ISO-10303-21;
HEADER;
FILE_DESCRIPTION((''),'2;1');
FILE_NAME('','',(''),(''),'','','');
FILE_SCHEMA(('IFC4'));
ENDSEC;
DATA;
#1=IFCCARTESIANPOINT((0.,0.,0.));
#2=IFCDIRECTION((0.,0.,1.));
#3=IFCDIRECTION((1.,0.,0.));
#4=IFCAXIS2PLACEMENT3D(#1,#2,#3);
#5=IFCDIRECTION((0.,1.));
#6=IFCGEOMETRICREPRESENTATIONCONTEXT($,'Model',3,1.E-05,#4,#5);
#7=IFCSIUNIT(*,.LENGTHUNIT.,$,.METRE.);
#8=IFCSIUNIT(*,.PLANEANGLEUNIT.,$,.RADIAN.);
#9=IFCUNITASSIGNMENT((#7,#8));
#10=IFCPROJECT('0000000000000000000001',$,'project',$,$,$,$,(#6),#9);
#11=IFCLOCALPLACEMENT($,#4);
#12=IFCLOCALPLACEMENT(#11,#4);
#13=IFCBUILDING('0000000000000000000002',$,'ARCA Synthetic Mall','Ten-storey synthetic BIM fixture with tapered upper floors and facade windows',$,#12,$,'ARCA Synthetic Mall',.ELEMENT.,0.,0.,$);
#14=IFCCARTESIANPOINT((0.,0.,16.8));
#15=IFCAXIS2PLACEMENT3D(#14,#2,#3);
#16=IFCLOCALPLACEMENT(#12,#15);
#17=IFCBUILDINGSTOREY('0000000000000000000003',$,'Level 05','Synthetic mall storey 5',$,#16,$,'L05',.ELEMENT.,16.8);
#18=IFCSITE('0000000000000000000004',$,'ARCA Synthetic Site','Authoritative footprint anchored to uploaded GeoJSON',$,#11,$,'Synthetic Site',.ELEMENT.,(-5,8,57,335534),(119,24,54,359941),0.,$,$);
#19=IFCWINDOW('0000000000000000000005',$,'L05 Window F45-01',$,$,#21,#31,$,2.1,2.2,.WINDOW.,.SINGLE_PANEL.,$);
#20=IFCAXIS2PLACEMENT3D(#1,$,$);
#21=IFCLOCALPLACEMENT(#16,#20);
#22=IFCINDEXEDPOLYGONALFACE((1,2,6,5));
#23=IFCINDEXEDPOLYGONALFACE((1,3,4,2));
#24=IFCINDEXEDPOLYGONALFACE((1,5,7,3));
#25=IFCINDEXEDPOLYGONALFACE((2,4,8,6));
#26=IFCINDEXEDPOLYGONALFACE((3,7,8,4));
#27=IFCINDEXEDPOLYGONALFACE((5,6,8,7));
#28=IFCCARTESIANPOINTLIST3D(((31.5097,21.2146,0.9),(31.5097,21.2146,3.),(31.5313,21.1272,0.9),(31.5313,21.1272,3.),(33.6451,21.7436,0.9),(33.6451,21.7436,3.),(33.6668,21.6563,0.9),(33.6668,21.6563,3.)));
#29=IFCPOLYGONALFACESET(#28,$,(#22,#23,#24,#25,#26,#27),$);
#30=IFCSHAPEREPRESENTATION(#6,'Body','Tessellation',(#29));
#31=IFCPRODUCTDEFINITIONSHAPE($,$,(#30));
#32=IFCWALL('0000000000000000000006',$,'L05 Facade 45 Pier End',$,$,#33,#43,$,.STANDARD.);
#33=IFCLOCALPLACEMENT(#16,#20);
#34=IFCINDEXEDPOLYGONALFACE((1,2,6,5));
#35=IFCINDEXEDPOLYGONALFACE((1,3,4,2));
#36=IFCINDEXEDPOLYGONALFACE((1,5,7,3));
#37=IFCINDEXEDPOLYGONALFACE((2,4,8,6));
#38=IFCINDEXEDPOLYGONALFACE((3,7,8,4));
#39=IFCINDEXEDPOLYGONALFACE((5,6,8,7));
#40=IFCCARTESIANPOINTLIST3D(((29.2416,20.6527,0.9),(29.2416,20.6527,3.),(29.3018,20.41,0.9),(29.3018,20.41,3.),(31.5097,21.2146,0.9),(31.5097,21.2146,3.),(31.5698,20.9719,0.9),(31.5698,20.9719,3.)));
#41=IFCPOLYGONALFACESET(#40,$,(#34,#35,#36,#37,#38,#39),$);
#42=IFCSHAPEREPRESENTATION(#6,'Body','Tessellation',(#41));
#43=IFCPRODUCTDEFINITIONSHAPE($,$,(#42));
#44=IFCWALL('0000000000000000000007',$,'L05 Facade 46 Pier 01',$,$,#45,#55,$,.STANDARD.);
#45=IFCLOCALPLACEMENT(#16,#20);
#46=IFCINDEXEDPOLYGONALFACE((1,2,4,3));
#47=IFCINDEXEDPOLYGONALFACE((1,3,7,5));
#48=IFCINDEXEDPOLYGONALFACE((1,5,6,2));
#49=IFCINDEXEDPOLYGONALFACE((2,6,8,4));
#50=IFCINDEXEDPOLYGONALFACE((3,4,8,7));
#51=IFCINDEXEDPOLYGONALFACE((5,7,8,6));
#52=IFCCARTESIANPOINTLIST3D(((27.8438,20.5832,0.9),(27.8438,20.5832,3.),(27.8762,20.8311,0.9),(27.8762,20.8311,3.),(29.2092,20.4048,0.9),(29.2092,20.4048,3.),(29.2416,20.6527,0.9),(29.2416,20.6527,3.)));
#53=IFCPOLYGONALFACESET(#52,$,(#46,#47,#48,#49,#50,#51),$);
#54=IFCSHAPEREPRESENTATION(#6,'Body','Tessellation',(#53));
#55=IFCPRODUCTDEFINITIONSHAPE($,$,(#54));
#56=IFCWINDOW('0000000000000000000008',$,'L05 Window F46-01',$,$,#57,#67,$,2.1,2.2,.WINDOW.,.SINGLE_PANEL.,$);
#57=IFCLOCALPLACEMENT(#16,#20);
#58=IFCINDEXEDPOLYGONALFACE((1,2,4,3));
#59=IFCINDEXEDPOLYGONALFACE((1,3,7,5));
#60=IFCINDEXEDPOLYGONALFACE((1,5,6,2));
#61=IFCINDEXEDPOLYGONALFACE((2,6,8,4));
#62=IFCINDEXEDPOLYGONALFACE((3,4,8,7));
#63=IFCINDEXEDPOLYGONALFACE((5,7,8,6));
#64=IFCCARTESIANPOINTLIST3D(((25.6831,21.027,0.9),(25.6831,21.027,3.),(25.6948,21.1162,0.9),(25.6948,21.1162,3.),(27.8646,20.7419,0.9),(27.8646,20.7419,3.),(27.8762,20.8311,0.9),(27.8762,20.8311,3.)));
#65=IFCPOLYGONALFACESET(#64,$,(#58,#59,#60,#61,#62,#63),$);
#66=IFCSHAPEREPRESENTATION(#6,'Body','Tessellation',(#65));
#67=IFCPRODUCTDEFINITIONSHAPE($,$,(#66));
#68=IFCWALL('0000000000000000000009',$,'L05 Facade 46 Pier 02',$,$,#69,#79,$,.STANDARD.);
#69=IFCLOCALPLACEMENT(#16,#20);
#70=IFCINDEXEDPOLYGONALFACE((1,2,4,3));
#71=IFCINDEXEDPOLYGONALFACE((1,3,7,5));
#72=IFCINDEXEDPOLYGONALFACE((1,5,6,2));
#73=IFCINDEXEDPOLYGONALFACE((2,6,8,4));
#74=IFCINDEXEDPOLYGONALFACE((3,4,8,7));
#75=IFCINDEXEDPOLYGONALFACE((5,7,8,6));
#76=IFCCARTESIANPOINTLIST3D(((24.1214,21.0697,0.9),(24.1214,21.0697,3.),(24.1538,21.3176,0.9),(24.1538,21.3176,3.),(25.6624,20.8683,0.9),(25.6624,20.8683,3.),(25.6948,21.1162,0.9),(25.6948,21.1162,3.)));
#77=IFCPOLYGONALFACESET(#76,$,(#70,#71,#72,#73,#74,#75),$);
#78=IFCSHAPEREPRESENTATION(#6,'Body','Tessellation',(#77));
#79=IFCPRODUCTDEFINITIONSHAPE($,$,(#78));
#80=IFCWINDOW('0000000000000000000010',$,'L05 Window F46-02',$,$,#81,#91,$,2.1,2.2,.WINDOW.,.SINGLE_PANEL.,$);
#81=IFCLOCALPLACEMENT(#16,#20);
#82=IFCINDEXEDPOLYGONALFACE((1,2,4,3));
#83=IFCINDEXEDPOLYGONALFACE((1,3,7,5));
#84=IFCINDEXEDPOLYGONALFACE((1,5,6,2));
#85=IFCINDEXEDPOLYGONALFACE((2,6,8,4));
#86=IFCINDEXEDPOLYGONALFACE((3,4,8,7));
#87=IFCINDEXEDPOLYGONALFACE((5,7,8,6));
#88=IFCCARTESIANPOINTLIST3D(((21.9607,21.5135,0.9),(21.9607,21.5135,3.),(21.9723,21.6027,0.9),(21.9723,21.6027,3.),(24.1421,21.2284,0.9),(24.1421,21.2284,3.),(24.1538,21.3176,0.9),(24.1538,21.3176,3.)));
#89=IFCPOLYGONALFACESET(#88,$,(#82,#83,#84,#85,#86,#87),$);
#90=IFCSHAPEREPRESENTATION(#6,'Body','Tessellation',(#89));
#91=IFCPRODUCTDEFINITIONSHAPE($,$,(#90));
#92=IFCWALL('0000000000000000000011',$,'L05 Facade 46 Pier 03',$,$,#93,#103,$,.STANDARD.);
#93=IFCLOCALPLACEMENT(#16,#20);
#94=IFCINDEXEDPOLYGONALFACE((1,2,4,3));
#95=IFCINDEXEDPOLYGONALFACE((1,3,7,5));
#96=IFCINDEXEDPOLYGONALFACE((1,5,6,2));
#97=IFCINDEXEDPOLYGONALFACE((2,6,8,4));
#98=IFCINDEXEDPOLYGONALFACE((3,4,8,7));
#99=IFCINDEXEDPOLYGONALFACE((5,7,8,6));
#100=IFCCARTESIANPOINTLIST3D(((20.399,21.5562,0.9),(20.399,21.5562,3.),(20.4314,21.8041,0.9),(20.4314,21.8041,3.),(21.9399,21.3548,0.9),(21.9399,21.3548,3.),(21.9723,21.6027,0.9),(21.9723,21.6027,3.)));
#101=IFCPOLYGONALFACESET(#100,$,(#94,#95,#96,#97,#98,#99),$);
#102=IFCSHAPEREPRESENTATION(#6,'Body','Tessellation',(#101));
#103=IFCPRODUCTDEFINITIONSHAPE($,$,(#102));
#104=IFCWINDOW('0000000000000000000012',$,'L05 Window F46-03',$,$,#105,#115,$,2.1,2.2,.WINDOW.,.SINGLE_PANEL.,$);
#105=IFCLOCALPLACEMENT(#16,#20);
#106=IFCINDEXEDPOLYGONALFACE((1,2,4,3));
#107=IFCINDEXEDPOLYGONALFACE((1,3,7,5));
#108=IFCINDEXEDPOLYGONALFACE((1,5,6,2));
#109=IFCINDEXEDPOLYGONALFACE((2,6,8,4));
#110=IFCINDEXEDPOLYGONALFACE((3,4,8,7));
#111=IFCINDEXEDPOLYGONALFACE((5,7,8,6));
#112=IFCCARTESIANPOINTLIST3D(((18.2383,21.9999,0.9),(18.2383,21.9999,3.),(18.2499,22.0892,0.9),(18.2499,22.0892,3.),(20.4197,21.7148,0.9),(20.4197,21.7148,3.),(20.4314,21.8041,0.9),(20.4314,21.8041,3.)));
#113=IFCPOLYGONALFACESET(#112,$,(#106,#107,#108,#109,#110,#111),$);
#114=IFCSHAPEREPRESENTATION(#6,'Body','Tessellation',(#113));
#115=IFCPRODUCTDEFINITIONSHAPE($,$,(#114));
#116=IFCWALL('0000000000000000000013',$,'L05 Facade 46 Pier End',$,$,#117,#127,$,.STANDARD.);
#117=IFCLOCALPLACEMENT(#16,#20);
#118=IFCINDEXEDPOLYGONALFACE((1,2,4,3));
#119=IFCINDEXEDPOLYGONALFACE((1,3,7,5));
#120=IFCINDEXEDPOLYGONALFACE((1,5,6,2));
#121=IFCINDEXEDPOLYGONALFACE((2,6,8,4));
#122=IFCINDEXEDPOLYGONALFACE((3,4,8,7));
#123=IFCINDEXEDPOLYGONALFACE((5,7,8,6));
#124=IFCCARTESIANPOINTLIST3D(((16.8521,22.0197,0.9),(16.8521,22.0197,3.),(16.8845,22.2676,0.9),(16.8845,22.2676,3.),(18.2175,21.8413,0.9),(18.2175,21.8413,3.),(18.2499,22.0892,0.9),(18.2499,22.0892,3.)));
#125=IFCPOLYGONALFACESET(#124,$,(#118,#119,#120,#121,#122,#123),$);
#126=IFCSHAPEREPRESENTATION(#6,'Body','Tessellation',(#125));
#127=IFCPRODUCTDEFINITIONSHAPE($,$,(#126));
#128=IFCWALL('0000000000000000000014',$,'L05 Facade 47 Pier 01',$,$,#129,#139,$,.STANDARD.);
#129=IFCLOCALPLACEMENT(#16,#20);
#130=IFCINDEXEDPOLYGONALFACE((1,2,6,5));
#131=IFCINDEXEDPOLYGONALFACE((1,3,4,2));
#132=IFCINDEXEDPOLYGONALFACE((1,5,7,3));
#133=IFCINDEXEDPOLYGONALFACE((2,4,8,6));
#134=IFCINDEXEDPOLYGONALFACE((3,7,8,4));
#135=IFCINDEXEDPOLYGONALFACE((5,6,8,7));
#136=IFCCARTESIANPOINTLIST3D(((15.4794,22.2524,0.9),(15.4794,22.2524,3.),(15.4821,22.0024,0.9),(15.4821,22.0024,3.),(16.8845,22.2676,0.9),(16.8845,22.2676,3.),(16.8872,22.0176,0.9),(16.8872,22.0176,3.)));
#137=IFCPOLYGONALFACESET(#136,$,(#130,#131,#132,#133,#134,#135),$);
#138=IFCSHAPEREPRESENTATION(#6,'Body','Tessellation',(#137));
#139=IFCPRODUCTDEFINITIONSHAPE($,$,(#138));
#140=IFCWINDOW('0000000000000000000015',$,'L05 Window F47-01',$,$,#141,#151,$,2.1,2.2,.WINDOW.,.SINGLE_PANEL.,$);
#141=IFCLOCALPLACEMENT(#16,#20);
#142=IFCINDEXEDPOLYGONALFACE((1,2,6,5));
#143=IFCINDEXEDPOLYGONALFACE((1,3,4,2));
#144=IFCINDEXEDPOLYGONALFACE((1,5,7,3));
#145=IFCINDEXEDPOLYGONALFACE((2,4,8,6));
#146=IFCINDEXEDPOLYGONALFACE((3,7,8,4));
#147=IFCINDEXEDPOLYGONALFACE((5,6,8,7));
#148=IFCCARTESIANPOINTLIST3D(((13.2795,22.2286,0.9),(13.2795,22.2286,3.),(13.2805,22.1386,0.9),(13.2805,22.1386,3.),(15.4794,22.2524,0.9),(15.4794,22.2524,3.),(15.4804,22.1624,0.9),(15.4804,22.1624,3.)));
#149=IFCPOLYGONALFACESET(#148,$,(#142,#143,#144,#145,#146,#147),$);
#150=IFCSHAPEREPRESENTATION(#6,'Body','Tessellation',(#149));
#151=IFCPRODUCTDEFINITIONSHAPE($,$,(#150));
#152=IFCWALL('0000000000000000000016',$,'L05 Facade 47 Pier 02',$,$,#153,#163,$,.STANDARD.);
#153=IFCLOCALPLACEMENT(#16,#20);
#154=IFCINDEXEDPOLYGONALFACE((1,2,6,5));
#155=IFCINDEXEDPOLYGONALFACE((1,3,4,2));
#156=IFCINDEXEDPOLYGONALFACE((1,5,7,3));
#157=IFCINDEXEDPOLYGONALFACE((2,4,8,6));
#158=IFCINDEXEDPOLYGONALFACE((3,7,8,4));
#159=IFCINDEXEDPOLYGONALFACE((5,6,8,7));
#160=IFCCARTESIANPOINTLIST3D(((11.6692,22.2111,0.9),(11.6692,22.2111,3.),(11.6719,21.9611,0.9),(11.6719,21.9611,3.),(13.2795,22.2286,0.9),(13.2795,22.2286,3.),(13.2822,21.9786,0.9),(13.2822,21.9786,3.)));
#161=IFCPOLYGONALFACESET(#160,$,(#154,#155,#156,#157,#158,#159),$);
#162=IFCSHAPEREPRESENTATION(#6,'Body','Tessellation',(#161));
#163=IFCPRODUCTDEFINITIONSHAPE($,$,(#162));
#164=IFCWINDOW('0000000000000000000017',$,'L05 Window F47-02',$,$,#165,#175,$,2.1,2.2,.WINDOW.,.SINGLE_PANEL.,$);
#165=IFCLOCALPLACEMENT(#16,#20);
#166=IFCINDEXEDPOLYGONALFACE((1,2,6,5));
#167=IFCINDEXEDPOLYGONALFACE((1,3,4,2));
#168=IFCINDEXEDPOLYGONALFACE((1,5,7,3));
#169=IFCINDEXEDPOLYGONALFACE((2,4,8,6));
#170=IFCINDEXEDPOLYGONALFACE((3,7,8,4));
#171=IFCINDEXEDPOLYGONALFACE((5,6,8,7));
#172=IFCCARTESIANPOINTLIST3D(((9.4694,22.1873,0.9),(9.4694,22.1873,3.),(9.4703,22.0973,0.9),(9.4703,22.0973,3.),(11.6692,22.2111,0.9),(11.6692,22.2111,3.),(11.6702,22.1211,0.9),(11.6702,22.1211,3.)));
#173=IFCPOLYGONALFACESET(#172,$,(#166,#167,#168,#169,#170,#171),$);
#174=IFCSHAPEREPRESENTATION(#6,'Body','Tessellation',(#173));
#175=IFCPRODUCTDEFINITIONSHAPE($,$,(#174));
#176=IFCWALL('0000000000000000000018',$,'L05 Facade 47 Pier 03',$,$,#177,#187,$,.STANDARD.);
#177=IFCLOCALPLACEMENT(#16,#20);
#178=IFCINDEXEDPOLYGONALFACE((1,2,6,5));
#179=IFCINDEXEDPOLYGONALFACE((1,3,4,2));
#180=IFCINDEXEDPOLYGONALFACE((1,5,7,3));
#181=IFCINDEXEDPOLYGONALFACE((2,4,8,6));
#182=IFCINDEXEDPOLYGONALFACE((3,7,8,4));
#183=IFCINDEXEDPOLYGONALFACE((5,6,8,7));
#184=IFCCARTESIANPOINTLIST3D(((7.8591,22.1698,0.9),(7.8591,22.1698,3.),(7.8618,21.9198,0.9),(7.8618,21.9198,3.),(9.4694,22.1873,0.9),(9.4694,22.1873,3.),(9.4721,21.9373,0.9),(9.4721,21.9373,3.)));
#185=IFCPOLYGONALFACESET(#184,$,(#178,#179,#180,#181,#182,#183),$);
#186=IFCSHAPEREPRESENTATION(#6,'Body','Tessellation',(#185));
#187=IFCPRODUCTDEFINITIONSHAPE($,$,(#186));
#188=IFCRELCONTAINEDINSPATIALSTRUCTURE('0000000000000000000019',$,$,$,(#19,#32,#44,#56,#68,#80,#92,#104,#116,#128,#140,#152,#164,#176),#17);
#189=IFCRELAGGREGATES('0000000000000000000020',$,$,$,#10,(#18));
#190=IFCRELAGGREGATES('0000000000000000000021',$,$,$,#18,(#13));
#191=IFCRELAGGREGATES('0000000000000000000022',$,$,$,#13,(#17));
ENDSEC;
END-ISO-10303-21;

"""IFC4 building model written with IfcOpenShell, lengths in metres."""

from ifc_helpers import new_model, si_unit, direction, frame, origin_with_axes, place, context, project, spatial, polyline, outline, extrude, element, save


model = new_model("IFC4")

# Units and contexts
model_context = context("Model", 3, precision=1e-05, world=origin_with_axes(), true_north=direction((0.0, 1.0)))
ifc_project = project(units=[si_unit("LENGTHUNIT", "METRE"), si_unit("PLANEANGLEUNIT", "RADIAN")], contexts=[model_context])

# Site, building, storey
site_placement = place(None, origin_with_axes())
site = spatial("IfcSite", under=ifc_project, at=site_placement, Name="ARCA Synthetic Site", Description="Authoritative footprint anchored to uploaded GeoJSON", LongName="Synthetic Site", CompositionType="ELEMENT", RefLatitude=(-5, 8, 57, 335534), RefLongitude=(119, 24, 54, 359941), RefElevation=0.0)
building_placement = place(site_placement, origin_with_axes())
building = spatial("IfcBuilding", under=site, at=building_placement, Name="ARCA Synthetic Mall", Description="Ten-storey synthetic BIM fixture with tapered upper floors and facade windows", LongName="ARCA Synthetic Mall", CompositionType="ELEMENT", ElevationOfRefHeight=0.0, ElevationOfTerrain=0.0)
storey_placement = place(building_placement, frame((0.0, 0.0, 16.8), z_axis=(0.0, 0.0, 1.0), x_axis=(1.0, 0.0, 0.0)))
storey = spatial("IfcBuildingStorey", under=building, at=storey_placement, Name="Level 05", Description="Synthetic mall storey 5", LongName="L05", CompositionType="ELEMENT", Elevation=16.8)

# Window
window_1_placement = place(storey_placement, frame((0.0, 0.0, 0.9), z_axis=(0.0, 0.0, 1.0), x_axis=(1.0, 0.0, 0.0)))
element("IfcWindow", 1, at=window_1_placement, inside=storey, Name="L05 Window F45-01", OverallHeight=2.1, OverallWidth=2.2, PartitioningType="SINGLE_PANEL", PredefinedType="WINDOW", context=model_context, shape_type="SweptSolid", body=[
    extrude(outline(polyline([(33.6451, 21.7436), (31.5097, 21.2146), (31.5313, 21.1272), (33.6668, 21.6563), (33.6451, 21.7436)])), origin_with_axes(), (0.0, 0.0, 1.0), 2.1),
])

# Walls
wall_1_placement = place(storey_placement, frame((0.0, 0.0, 0.9), z_axis=(0.0, 0.0, 1.0), x_axis=(1.0, 0.0, 0.0)))
element("IfcWall", 2, at=wall_1_placement, inside=storey, Name="L05 Facade 45 Pier End", PredefinedType="STANDARD", context=model_context, shape_type="SweptSolid", body=[
    extrude(outline(polyline([(31.5097, 21.2146), (29.2416, 20.6527), (29.3018, 20.41), (31.5698, 20.9719), (31.5097, 21.2146)])), origin_with_axes(), (0.0, 0.0, 1.0), 2.1),
])
wall_2_placement = place(storey_placement, frame((0.0, 0.0, 0.9), z_axis=(0.0, 0.0, 1.0), x_axis=(1.0, 0.0, 0.0)))
element("IfcWall", 3, at=wall_2_placement, inside=storey, Name="L05 Facade 46 Pier 01", PredefinedType="STANDARD", context=model_context, shape_type="SweptSolid", body=[
    extrude(outline(polyline([(29.2416, 20.6527), (27.8762, 20.8311), (27.8438, 20.5832), (29.2092, 20.4048), (29.2416, 20.6527)])), origin_with_axes(), (0.0, 0.0, 1.0), 2.1),
])

# Window
window_2_placement = place(storey_placement, frame((0.0, 0.0, 0.9), z_axis=(0.0, 0.0, 1.0), x_axis=(1.0, 0.0, 0.0)))
element("IfcWindow", 4, at=window_2_placement, inside=storey, Name="L05 Window F46-01", OverallHeight=2.1, OverallWidth=2.2, PartitioningType="SINGLE_PANEL", PredefinedType="WINDOW", context=model_context, shape_type="SweptSolid", body=[
    extrude(outline(polyline([(27.8762, 20.8311), (25.6948, 21.1162), (25.6831, 21.027), (27.8646, 20.7419), (27.8762, 20.8311)])), origin_with_axes(), (0.0, 0.0, 1.0), 2.1),
])

# Wall
wall_3_placement = place(storey_placement, frame((0.0, 0.0, 0.9), z_axis=(0.0, 0.0, 1.0), x_axis=(1.0, 0.0, 0.0)))
element("IfcWall", 5, at=wall_3_placement, inside=storey, Name="L05 Facade 46 Pier 02", PredefinedType="STANDARD", context=model_context, shape_type="SweptSolid", body=[
    extrude(outline(polyline([(25.6948, 21.1162), (24.1538, 21.3176), (24.1214, 21.0697), (25.6624, 20.8683), (25.6948, 21.1162)])), origin_with_axes(), (0.0, 0.0, 1.0), 2.1),
])

# Window
window_3_placement = place(storey_placement, frame((0.0, 0.0, 0.9), z_axis=(0.0, 0.0, 1.0), x_axis=(1.0, 0.0, 0.0)))
element("IfcWindow", 6, at=window_3_placement, inside=storey, Name="L05 Window F46-02", OverallHeight=2.1, OverallWidth=2.2, PartitioningType="SINGLE_PANEL", PredefinedType="WINDOW", context=model_context, shape_type="SweptSolid", body=[
    extrude(outline(polyline([(24.1538, 21.3176), (21.9723, 21.6027), (21.9607, 21.5135), (24.1421, 21.2284), (24.1538, 21.3176)])), origin_with_axes(), (0.0, 0.0, 1.0), 2.1),
])

# Wall
wall_4_placement = place(storey_placement, frame((0.0, 0.0, 0.9), z_axis=(0.0, 0.0, 1.0), x_axis=(1.0, 0.0, 0.0)))
element("IfcWall", 7, at=wall_4_placement, inside=storey, Name="L05 Facade 46 Pier 03", PredefinedType="STANDARD", context=model_context, shape_type="SweptSolid", body=[
    extrude(outline(polyline([(21.9723, 21.6027), (20.4314, 21.8041), (20.399, 21.5562), (21.9399, 21.3548), (21.9723, 21.6027)])), origin_with_axes(), (0.0, 0.0, 1.0), 2.1),
])

# Window
window_4_placement = place(storey_placement, frame((0.0, 0.0, 0.9), z_axis=(0.0, 0.0, 1.0), x_axis=(1.0, 0.0, 0.0)))
element("IfcWindow", 8, at=window_4_placement, inside=storey, Name="L05 Window F46-03", OverallHeight=2.1, OverallWidth=2.2, PartitioningType="SINGLE_PANEL", PredefinedType="WINDOW", context=model_context, shape_type="SweptSolid", body=[
    extrude(outline(polyline([(20.4314, 21.8041), (18.2499, 22.0892), (18.2383, 21.9999), (20.4197, 21.7148), (20.4314, 21.8041)])), origin_with_axes(), (0.0, 0.0, 1.0), 2.1),
])

# Walls
wall_5_placement = place(storey_placement, frame((0.0, 0.0, 0.9), z_axis=(0.0, 0.0, 1.0), x_axis=(1.0, 0.0, 0.0)))
element("IfcWall", 9, at=wall_5_placement, inside=storey, Name="L05 Facade 46 Pier End", PredefinedType="STANDARD", context=model_context, shape_type="SweptSolid", body=[
    extrude(outline(polyline([(18.2499, 22.0892), (16.8845, 22.2676), (16.8521, 22.0197), (18.2175, 21.8413), (18.2499, 22.0892)])), origin_with_axes(), (0.0, 0.0, 1.0), 2.1),
])
wall_6_placement = place(storey_placement, frame((0.0, 0.0, 0.9), z_axis=(0.0, 0.0, 1.0), x_axis=(1.0, 0.0, 0.0)))
element("IfcWall", 10, at=wall_6_placement, inside=storey, Name="L05 Facade 47 Pier 01", PredefinedType="STANDARD", context=model_context, shape_type="SweptSolid", body=[
    extrude(outline(polyline([(16.8845, 22.2676), (15.4794, 22.2524), (15.4821, 22.0024), (16.8872, 22.0176), (16.8845, 22.2676)])), origin_with_axes(), (0.0, 0.0, 1.0), 2.1),
])

# Window
window_5_placement = place(storey_placement, frame((0.0, 0.0, 0.9), z_axis=(0.0, 0.0, 1.0), x_axis=(1.0, 0.0, 0.0)))
element("IfcWindow", 11, at=window_5_placement, inside=storey, Name="L05 Window F47-01", OverallHeight=2.1, OverallWidth=2.2, PartitioningType="SINGLE_PANEL", PredefinedType="WINDOW", context=model_context, shape_type="SweptSolid", body=[
    extrude(outline(polyline([(15.4794, 22.2524), (13.2795, 22.2286), (13.2805, 22.1386), (15.4804, 22.1624), (15.4794, 22.2524)])), origin_with_axes(), (0.0, 0.0, 1.0), 2.1),
])

# Wall
wall_7_placement = place(storey_placement, frame((0.0, 0.0, 0.9), z_axis=(0.0, 0.0, 1.0), x_axis=(1.0, 0.0, 0.0)))
element("IfcWall", 12, at=wall_7_placement, inside=storey, Name="L05 Facade 47 Pier 02", PredefinedType="STANDARD", context=model_context, shape_type="SweptSolid", body=[
    extrude(outline(polyline([(13.2795, 22.2286), (11.6692, 22.2111), (11.6719, 21.9611), (13.2822, 21.9786), (13.2795, 22.2286)])), origin_with_axes(), (0.0, 0.0, 1.0), 2.1),
])

# Window
window_6_placement = place(storey_placement, frame((0.0, 0.0, 0.9), z_axis=(0.0, 0.0, 1.0), x_axis=(1.0, 0.0, 0.0)))
element("IfcWindow", 13, at=window_6_placement, inside=storey, Name="L05 Window F47-02", OverallHeight=2.1, OverallWidth=2.2, PartitioningType="SINGLE_PANEL", PredefinedType="WINDOW", context=model_context, shape_type="SweptSolid", body=[
    extrude(outline(polyline([(11.6692, 22.2111), (9.4694, 22.1873), (9.4703, 22.0973), (11.6702, 22.1211), (11.6692, 22.2111)])), origin_with_axes(), (0.0, 0.0, 1.0), 2.1),
])

# Wall
wall_8_placement = place(storey_placement, frame((0.0, 0.0, 0.9), z_axis=(0.0, 0.0, 1.0), x_axis=(1.0, 0.0, 0.0)))
element("IfcWall", 14, at=wall_8_placement, inside=storey, Name="L05 Facade 47 Pier 03", PredefinedType="STANDARD", context=model_context, shape_type="SweptSolid", body=[
    extrude(outline(polyline([(9.4694, 22.1873), (7.8591, 22.1698), (7.8618, 21.9198), (9.4721, 21.9373), (9.4694, 22.1873)])), origin_with_axes(), (0.0, 0.0, 1.0), 2.1),
])

save(model, "model.ifc")
